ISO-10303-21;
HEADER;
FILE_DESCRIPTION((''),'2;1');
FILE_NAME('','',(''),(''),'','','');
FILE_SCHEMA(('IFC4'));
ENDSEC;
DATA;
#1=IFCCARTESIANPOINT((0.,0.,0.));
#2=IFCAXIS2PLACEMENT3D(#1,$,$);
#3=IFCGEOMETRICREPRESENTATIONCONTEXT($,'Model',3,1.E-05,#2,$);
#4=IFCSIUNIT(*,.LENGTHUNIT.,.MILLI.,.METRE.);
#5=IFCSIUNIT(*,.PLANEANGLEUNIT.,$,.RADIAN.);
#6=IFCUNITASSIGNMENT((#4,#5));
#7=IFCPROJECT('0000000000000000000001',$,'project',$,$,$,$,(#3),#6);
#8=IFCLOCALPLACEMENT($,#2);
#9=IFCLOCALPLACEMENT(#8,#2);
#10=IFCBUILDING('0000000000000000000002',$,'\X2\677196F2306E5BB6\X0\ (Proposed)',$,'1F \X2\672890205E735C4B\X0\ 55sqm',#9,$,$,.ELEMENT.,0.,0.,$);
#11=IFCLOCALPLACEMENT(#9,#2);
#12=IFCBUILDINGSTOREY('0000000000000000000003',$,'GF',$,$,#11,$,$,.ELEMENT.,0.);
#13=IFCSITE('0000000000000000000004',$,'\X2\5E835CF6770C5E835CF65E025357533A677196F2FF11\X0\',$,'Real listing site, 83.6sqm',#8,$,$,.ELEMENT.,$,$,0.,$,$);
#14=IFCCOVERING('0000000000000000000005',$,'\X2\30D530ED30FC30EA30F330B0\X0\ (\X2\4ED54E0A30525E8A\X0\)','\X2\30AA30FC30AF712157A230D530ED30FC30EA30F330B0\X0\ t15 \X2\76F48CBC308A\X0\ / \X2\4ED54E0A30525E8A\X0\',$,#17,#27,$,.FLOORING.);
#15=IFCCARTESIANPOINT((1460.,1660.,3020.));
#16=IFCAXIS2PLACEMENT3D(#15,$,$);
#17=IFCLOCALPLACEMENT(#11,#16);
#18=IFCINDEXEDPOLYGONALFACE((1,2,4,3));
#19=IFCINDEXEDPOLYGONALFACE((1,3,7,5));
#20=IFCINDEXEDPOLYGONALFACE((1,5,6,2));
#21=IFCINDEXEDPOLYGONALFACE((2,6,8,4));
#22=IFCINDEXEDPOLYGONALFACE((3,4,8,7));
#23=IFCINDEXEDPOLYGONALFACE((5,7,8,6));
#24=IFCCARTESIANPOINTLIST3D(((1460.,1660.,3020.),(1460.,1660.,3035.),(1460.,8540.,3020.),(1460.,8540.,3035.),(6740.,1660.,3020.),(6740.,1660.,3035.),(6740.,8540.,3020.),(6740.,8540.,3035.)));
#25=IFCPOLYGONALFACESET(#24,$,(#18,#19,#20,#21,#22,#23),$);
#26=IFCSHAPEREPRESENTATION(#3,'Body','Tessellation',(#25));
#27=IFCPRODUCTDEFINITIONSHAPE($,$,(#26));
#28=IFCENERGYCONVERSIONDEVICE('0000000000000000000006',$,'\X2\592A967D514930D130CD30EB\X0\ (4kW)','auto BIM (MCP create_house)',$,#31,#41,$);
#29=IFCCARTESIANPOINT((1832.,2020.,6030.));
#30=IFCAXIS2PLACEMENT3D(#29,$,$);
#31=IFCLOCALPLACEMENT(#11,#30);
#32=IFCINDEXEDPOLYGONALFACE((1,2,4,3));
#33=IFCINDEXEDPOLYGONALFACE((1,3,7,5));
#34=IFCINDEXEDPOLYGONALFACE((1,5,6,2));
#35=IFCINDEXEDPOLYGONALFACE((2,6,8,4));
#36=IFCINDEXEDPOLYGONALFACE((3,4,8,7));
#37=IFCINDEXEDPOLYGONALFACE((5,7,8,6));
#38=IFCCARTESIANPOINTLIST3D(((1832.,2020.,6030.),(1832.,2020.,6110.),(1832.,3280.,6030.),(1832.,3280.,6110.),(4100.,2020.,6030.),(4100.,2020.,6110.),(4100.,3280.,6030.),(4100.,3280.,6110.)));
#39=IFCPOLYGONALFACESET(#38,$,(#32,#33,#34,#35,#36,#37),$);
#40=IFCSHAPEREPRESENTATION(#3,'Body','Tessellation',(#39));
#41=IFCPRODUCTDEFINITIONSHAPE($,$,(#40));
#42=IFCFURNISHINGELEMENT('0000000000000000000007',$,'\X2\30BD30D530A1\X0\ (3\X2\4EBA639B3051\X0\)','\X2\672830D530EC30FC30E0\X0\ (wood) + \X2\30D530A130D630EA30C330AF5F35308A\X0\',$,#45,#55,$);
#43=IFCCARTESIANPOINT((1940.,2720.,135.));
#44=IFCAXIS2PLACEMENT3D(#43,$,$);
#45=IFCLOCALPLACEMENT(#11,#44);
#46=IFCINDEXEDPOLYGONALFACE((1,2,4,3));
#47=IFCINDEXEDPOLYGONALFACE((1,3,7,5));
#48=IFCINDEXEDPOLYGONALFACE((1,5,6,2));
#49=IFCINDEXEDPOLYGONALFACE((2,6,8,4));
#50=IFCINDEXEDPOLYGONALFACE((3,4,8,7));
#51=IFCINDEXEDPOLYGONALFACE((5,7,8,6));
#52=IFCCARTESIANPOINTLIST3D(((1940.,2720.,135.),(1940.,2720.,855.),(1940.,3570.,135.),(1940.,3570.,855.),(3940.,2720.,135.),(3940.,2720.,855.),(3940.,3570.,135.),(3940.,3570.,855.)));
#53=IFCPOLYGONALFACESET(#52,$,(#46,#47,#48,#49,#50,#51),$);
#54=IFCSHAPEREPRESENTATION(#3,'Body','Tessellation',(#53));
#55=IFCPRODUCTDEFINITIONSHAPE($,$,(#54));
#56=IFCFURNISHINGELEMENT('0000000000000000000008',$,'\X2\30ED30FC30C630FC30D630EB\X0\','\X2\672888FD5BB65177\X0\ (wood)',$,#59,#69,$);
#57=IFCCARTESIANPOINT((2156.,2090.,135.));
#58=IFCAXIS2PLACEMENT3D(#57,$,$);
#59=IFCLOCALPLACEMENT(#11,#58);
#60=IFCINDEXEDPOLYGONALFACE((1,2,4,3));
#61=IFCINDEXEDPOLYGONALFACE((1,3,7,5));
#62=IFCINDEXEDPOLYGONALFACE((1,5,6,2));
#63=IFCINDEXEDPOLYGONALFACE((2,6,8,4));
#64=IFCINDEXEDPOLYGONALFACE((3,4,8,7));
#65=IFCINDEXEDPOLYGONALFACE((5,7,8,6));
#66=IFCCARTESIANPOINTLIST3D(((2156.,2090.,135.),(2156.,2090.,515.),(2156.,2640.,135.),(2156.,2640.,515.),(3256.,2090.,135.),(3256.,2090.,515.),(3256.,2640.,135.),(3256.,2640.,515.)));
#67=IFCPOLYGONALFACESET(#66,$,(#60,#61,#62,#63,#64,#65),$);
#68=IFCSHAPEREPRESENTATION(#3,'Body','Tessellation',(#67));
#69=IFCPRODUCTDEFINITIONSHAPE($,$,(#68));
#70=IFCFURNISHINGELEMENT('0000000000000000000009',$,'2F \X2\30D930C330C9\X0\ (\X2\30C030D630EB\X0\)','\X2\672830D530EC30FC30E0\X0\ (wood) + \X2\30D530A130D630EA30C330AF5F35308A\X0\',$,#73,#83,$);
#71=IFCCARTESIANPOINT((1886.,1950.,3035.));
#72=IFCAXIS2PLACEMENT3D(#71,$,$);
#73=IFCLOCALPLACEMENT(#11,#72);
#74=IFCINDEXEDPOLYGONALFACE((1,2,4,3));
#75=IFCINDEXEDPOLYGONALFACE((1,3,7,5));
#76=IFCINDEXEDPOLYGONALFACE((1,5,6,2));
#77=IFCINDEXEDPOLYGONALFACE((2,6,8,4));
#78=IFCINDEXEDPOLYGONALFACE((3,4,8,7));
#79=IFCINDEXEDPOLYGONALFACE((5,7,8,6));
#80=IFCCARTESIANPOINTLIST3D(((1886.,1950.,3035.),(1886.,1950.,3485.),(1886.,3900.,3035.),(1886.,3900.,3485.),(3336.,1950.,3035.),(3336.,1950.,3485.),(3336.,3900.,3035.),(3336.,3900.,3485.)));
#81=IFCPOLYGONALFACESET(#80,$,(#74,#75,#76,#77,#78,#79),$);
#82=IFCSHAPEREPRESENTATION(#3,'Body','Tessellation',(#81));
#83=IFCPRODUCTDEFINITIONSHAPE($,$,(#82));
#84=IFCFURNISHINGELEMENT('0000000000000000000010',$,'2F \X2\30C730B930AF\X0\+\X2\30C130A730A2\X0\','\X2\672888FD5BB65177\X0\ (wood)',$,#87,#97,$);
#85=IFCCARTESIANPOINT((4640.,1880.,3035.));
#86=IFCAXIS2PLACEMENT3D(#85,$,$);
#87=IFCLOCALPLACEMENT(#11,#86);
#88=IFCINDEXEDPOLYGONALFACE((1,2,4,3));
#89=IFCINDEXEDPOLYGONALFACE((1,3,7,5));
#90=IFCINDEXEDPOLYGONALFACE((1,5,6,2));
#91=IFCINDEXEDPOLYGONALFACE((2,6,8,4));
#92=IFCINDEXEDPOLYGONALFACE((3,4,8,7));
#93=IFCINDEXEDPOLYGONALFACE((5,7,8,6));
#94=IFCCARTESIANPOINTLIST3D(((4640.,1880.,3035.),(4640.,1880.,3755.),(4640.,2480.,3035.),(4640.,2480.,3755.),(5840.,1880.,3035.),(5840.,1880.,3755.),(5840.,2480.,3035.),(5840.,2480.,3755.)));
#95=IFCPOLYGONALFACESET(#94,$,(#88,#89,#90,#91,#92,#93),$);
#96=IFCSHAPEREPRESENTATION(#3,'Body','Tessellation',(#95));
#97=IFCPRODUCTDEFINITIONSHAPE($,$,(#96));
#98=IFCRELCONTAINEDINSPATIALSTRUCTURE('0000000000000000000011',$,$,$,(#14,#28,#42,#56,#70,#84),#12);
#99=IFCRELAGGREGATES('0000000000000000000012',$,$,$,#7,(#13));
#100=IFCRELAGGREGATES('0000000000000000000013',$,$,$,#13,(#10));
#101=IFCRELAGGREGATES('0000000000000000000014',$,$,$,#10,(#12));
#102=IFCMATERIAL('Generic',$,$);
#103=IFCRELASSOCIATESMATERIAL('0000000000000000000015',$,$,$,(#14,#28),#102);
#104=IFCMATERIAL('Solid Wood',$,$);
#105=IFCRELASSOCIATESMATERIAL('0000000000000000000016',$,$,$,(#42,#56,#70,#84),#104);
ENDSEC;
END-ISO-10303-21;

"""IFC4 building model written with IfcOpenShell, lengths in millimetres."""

from ifc_helpers import new_model, si_unit, frame, frame_2d, origin, place, context, project, spatial, rectangle, extrude, material, element, save


model = new_model("IFC4")

# Units and contexts
model_context = context("Model", 3, precision=1e-05, world=origin())
ifc_project = project(units=[si_unit("LENGTHUNIT", "METRE", prefix="MILLI"), si_unit("PLANEANGLEUNIT", "RADIAN")], contexts=[model_context])

# Site, building, storey
site_placement = place(None, origin())
site = spatial("IfcSite", under=ifc_project, at=site_placement, Name="広島県広島市南区東雲１", ObjectType="Real listing site, 83.6sqm", CompositionType="ELEMENT", RefElevation=0.0)
building_placement = place(site_placement, origin())
building = spatial("IfcBuilding", under=site, at=building_placement, Name="東雲の家 (Proposed)", ObjectType="1F 木造平屋 55sqm", CompositionType="ELEMENT", ElevationOfRefHeight=0.0, ElevationOfTerrain=0.0)
storey_placement = place(building_placement, origin())
storey = spatial("IfcBuildingStorey", under=building, at=storey_placement, Name="GF", CompositionType="ELEMENT", Elevation=0.0)

# Shared definitions
ifc_material_1 = material(Name="Solid Wood")

# Shared definitions
ifc_material_2 = material(Name="Generic")

# Covering
covering_placement = place(storey_placement, frame((1460.0, 1660.0, 3020.0)))
element("IfcCovering", 1, at=covering_placement, inside=storey, material=ifc_material_2, Name="フローリング (仕上げ床)", Description="オーク無垢フローリング t15 直貼り / 仕上げ床", PredefinedType="FLOORING", context=model_context, shape_type="SweptSolid", body=[
    extrude(rectangle(XDim=5280.0, YDim=6880.0, at=frame_2d((2640.0, 3440.0))), frame((1460.0, 1660.0, 3020.0)), (0.0, 0.0, 1.0), 15.0),
])

# Energy conversion device
energy_conversion_device_placement = place(storey_placement, frame((1832.0, 2020.0, 6030.0)))
element("IfcEnergyConversionDevice", 2, at=energy_conversion_device_placement, inside=storey, material=ifc_material_2, Name="太陽光パネル (4kW)", Description="auto BIM (MCP create_house)", context=model_context, shape_type="SweptSolid", body=[
    extrude(rectangle(XDim=2268.0, YDim=1260.0, at=frame_2d((1134.0, 630.0))), frame((1832.0, 2020.0, 6030.0)), (0.0, 0.0, 1.0), 80.0),
])

# Furnishing elements
furnishing_1_placement = place(storey_placement, frame((1940.0, 2720.0, 135.0)))
element("IfcFurnishingElement", 3, at=furnishing_1_placement, inside=storey, material=ifc_material_1, Name="ソファ (3人掛け)", Description="木フレーム (wood) + ファブリック張り", context=model_context, shape_type="SweptSolid", body=[
    extrude(rectangle(XDim=2000.0, YDim=850.0, at=frame_2d((1000.0, 425.0))), frame((1940.0, 2720.0, 135.0)), (0.0, 0.0, 1.0), 720.0),
])
furnishing_2_placement = place(storey_placement, frame((2156.0, 2090.0, 135.0)))
element("IfcFurnishingElement", 4, at=furnishing_2_placement, inside=storey, material=ifc_material_1, Name="ローテーブル", Description="木製家具 (wood)", context=model_context, shape_type="SweptSolid", body=[
    extrude(rectangle(XDim=1100.0, YDim=550.0, at=frame_2d((550.0, 275.0))), frame((2156.0, 2090.0, 135.0)), (0.0, 0.0, 1.0), 380.0),
])
furnishing_3_placement = place(storey_placement, frame((1886.0, 1950.0, 3035.0)))
element("IfcFurnishingElement", 5, at=furnishing_3_placement, inside=storey, material=ifc_material_1, Name="2F ベッド (ダブル)", Description="木フレーム (wood) + ファブリック張り", context=model_context, shape_type="SweptSolid", body=[
    extrude(rectangle(XDim=1450.0, YDim=1950.0, at=frame_2d((725.0, 975.0))), frame((1886.0, 1950.0, 3035.0)), (0.0, 0.0, 1.0), 450.0),
])
furnishing_4_placement = place(storey_placement, frame((4640.0, 1880.0, 3035.0)))
element("IfcFurnishingElement", 6, at=furnishing_4_placement, inside=storey, material=ifc_material_1, Name="2F デスク+チェア", Description="木製家具 (wood)", context=model_context, shape_type="SweptSolid", body=[
    extrude(rectangle(XDim=1200.0, YDim=600.0, at=frame_2d((600.0, 300.0))), frame((4640.0, 1880.0, 3035.0)), (0.0, 0.0, 1.0), 720.0),
])

save(model, "model.ifc")
